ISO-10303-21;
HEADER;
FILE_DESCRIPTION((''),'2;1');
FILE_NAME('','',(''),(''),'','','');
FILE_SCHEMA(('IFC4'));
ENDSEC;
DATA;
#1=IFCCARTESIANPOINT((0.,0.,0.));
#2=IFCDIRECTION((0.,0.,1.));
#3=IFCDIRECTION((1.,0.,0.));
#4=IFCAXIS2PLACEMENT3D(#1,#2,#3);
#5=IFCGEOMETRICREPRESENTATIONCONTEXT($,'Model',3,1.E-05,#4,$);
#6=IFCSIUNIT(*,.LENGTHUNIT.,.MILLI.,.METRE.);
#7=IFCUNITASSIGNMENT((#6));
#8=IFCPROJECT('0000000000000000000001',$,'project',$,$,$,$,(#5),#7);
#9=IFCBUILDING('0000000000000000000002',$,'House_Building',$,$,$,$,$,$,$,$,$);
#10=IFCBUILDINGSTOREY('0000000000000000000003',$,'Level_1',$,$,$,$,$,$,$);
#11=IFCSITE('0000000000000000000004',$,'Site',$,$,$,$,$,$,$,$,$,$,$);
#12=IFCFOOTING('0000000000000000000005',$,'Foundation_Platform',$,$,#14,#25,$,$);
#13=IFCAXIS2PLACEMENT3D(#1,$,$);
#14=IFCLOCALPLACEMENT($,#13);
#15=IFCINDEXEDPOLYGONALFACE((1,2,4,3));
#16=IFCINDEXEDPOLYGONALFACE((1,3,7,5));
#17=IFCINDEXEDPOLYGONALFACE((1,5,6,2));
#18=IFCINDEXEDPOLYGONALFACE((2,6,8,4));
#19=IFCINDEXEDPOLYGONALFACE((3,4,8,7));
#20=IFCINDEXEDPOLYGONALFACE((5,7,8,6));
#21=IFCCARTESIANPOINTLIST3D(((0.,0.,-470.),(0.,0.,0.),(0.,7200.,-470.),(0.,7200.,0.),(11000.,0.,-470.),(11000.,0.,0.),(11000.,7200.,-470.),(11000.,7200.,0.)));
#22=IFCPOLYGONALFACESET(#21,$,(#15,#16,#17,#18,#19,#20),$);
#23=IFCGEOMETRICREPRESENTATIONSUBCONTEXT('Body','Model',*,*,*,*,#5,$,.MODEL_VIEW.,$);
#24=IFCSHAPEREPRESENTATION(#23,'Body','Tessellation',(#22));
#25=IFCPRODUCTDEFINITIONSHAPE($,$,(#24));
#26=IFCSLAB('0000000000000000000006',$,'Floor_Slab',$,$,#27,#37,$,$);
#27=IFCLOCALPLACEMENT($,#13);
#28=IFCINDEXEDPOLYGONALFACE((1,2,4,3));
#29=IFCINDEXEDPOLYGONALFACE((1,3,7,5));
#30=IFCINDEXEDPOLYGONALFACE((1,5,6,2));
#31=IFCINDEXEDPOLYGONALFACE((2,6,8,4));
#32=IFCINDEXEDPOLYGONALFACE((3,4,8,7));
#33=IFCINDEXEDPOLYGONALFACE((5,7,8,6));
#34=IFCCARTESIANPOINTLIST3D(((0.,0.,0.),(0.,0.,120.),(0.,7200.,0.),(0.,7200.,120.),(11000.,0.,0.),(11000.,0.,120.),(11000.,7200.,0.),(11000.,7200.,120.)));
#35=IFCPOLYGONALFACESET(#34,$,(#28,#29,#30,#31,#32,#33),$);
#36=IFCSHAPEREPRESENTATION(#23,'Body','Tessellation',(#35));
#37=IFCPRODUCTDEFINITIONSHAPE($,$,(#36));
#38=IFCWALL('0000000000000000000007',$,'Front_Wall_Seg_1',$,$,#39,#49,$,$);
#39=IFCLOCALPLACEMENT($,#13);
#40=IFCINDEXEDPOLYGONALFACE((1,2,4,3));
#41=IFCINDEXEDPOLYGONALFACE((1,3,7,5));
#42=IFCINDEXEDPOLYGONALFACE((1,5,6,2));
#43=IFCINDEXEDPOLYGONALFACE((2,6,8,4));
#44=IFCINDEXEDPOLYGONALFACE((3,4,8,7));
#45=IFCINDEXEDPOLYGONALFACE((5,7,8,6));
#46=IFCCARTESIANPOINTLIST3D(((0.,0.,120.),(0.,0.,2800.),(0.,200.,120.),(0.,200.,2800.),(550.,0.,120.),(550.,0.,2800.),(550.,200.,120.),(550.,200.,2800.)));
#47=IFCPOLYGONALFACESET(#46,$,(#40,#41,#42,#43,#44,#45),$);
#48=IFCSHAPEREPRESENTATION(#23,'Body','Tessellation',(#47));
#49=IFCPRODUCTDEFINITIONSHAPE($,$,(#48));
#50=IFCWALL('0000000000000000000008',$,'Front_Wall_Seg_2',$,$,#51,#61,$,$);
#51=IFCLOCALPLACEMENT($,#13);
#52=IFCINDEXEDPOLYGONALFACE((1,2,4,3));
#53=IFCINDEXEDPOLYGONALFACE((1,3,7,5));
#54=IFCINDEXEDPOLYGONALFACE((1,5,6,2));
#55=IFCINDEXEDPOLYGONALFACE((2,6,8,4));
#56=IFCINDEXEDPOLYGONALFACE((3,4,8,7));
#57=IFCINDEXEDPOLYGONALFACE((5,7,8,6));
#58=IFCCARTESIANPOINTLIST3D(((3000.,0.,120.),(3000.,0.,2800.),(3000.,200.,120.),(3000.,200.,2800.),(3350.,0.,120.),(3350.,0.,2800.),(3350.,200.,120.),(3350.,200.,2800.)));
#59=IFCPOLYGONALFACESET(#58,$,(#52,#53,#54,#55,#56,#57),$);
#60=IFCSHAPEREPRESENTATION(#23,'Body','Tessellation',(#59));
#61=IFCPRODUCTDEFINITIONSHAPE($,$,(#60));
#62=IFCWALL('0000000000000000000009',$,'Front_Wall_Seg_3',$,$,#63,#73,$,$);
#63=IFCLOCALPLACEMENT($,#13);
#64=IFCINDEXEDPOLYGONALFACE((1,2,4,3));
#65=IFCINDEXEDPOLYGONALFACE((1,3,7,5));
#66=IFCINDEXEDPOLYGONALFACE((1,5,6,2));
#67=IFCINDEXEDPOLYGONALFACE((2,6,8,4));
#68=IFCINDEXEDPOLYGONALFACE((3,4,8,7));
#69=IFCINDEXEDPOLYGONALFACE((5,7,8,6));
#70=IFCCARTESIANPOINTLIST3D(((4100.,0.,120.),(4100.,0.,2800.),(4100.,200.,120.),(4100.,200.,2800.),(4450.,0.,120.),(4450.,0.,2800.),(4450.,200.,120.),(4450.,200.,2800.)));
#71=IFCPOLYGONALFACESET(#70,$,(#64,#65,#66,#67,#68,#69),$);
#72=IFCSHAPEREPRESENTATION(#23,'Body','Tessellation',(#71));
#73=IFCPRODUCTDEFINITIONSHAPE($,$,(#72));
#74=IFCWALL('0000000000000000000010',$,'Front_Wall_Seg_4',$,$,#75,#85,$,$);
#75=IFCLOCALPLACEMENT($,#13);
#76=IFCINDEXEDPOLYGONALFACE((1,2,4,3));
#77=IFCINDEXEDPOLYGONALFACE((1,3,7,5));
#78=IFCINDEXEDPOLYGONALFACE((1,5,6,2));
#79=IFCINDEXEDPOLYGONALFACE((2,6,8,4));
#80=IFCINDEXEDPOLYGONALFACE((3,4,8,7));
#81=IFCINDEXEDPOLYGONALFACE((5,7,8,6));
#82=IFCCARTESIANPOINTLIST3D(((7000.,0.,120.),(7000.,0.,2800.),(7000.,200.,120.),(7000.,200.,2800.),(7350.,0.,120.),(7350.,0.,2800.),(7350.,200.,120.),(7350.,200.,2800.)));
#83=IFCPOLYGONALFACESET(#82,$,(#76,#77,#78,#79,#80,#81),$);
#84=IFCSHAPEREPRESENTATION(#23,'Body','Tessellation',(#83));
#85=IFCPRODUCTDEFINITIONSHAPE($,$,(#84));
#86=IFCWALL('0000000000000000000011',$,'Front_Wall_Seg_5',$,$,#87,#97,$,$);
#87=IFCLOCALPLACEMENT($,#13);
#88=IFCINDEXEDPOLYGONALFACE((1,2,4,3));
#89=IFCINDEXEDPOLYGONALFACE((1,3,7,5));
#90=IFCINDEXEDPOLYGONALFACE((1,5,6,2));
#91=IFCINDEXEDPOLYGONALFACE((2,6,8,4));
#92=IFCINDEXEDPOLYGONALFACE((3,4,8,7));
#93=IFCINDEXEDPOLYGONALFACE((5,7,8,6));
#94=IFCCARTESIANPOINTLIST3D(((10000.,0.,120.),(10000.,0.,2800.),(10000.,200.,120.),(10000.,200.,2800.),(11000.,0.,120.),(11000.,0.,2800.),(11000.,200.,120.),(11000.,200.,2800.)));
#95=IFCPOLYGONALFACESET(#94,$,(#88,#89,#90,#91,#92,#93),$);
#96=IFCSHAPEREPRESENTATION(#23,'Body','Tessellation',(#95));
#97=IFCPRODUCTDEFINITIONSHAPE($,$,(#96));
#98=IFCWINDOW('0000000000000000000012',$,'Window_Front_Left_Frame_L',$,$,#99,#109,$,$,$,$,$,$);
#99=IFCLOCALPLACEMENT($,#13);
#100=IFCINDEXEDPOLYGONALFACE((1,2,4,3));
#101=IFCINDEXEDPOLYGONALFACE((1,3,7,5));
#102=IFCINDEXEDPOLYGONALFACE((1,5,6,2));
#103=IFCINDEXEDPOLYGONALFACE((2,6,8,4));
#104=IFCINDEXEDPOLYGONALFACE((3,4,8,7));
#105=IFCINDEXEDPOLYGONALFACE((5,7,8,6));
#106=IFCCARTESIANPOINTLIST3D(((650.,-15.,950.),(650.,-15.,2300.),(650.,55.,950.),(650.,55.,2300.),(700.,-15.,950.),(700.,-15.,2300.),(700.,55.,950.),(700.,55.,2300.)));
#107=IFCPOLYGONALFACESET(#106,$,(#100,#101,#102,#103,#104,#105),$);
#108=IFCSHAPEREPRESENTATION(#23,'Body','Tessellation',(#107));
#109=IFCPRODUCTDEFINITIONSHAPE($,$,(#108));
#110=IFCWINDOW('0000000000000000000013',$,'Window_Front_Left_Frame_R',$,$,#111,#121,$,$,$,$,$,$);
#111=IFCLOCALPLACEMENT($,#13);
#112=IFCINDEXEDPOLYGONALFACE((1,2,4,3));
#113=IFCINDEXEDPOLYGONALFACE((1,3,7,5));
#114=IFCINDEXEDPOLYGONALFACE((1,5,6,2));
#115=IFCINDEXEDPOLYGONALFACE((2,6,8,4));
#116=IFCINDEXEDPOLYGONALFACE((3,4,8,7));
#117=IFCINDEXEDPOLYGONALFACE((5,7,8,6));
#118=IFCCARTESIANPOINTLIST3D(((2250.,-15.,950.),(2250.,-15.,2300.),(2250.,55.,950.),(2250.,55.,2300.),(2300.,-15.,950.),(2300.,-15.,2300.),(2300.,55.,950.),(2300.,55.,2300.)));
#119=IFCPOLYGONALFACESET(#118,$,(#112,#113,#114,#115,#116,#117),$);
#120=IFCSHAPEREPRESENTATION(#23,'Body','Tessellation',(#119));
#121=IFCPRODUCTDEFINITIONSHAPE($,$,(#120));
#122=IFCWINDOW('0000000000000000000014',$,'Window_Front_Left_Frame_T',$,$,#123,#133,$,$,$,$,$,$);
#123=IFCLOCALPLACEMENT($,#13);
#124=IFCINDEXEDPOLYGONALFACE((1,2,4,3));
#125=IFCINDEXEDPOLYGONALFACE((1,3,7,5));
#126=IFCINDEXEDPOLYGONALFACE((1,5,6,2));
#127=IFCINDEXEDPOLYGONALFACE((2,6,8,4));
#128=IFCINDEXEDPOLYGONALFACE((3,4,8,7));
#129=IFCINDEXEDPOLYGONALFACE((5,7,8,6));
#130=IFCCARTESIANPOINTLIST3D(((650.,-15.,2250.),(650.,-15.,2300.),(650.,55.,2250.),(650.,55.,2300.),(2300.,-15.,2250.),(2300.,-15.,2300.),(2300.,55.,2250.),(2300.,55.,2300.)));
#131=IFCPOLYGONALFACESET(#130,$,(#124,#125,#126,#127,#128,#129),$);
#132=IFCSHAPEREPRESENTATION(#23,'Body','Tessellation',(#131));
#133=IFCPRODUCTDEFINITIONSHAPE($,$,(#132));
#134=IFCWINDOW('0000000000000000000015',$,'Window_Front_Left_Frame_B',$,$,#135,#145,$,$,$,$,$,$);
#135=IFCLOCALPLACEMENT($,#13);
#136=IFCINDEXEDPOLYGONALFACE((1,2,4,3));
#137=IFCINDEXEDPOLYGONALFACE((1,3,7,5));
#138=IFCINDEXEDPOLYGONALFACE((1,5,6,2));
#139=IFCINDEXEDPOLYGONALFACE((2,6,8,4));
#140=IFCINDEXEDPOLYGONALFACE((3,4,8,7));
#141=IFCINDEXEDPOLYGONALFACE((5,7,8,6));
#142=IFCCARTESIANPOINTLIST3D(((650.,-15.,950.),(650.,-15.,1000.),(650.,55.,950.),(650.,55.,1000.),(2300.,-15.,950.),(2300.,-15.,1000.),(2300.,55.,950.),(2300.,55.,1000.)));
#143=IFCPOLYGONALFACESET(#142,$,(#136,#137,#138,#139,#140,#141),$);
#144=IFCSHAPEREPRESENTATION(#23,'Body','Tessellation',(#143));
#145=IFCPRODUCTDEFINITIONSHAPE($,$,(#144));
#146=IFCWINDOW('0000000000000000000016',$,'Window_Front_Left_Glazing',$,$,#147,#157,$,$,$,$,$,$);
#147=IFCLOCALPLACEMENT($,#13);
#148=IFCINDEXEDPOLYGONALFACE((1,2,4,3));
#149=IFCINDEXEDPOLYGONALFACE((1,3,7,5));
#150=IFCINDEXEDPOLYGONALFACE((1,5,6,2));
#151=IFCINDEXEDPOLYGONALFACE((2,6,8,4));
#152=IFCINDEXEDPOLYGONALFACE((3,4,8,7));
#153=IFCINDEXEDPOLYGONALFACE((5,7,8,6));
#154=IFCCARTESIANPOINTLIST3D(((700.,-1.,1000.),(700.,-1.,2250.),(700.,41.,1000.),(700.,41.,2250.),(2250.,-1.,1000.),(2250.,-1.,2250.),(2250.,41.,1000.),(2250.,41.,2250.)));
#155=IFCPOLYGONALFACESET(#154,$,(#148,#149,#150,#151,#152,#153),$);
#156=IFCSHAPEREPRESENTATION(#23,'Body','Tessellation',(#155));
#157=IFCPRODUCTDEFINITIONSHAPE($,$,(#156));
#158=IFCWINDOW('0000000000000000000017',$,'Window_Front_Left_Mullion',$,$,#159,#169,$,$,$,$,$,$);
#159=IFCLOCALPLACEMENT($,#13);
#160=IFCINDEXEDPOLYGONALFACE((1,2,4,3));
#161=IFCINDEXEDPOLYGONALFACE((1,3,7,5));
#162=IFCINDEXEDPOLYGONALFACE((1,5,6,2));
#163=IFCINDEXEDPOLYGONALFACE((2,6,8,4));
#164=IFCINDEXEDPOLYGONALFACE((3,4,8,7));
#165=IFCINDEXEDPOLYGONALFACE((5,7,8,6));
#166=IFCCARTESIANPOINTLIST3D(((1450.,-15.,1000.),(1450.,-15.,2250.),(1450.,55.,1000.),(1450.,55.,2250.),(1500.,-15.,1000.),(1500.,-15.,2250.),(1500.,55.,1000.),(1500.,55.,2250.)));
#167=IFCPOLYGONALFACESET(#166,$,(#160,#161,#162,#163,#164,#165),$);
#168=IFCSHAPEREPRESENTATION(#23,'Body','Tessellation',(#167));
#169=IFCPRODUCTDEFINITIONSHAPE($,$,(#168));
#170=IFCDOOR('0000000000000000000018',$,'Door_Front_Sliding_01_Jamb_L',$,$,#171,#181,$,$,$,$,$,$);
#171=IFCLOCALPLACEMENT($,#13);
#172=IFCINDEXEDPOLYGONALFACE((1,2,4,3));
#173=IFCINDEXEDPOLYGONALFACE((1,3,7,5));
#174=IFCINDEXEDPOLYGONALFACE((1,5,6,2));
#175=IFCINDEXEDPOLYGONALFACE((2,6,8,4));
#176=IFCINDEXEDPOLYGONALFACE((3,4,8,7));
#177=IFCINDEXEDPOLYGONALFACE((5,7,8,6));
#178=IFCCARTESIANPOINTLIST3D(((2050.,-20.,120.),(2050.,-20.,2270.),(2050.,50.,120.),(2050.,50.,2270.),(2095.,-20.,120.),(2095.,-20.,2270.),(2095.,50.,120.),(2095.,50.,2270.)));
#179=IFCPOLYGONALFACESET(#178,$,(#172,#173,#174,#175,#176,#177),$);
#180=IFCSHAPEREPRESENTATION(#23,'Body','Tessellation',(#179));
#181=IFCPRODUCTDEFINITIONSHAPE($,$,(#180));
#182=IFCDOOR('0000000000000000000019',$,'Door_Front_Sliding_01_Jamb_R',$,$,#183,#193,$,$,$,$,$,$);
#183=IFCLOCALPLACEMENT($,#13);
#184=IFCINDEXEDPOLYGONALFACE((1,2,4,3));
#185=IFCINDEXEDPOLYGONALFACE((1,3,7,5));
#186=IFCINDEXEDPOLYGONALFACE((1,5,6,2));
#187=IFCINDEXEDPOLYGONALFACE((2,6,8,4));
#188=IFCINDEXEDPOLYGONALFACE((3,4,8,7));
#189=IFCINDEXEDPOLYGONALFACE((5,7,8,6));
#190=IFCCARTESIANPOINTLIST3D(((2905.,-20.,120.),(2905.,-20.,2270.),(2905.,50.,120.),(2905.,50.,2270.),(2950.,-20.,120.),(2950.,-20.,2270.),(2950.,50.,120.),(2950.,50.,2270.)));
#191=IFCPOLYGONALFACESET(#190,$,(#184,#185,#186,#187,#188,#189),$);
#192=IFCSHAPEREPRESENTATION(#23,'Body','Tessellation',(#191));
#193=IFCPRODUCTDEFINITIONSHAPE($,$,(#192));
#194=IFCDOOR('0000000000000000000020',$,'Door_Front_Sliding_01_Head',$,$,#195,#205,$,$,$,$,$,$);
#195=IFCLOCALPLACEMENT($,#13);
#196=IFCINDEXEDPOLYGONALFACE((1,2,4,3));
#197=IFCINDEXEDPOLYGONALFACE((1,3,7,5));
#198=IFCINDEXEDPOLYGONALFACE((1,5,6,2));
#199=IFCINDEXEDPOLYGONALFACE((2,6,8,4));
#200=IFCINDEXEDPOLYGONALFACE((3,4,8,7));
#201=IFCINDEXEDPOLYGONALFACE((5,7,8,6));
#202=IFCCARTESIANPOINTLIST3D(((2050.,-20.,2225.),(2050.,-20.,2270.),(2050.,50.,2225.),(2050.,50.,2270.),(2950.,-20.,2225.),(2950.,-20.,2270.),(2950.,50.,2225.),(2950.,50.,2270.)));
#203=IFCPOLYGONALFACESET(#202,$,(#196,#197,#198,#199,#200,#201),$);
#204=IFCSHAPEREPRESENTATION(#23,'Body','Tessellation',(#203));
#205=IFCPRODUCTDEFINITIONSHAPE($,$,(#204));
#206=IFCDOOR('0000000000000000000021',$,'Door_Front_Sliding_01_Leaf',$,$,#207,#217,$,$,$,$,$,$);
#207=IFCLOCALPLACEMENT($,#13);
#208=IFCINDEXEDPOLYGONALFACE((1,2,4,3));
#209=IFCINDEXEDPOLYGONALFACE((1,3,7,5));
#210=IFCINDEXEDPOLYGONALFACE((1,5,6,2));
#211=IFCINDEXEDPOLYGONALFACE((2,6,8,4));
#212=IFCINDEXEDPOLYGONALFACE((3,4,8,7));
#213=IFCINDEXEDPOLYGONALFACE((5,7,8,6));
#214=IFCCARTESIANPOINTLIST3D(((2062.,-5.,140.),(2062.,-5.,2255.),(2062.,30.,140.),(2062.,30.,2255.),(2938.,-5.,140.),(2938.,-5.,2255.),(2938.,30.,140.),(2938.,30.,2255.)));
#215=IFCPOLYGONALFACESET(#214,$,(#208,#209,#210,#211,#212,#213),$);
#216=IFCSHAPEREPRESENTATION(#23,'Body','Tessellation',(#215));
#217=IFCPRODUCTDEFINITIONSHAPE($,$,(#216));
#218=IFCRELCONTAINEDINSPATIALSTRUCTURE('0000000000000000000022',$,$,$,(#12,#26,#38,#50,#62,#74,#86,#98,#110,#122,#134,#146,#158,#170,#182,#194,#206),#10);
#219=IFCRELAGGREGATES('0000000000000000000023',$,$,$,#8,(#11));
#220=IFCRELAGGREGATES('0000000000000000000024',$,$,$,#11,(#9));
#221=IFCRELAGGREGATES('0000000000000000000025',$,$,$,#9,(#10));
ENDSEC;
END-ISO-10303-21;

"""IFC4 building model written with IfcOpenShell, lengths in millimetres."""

from ifc_helpers import new_model, si_unit, frame, origin_with_axes, context, subcontext, project, spatial, polyline, outline, extrude, element, save


model = new_model("IFC4")

# Units and contexts
model_context = context("Model", 3, precision=1e-05, world=origin_with_axes())
body_context = subcontext(model_context, "Body", "Model", "MODEL_VIEW")
ifc_project = project(units=[si_unit("LENGTHUNIT", "METRE", prefix="MILLI")], contexts=[model_context])

# Site, building, storey
site = spatial("IfcSite", under=ifc_project, Name="Site")
building = spatial("IfcBuilding", under=site, Name="House_Building")
storey = spatial("IfcBuildingStorey", under=building, Name="Level_1")

# Footing
element("IfcFooting", 1, inside=storey, Name="Foundation_Platform", context=body_context, shape_type="SweptSolid", body=[
    extrude(outline(polyline([(0.0, 0.0), (11000.0, 0.0), (11000.0, 7200.0), (0.0, 7200.0), (0.0, 0.0)])), frame((0.0, 0.0, -470.0), z_axis=(0.0, 0.0, 1.0), x_axis=(1.0, 0.0, 0.0)), (0.0, 0.0, 1.0), 470.0),
])

# Slab
element("IfcSlab", 2, inside=storey, Name="Floor_Slab", context=body_context, shape_type="SweptSolid", body=[
    extrude(outline(polyline([(0.0, 0.0), (11000.0, 0.0), (11000.0, 7200.0), (0.0, 7200.0), (0.0, 0.0)])), origin_with_axes(), (0.0, 0.0, 1.0), 120.0),
])

# Walls
element("IfcWall", 3, inside=storey, Name="Front_Wall_Seg_1", context=body_context, shape_type="SweptSolid", body=[
    extrude(outline(polyline([(0.0, 0.0), (550.0, 0.0), (550.0, 200.0), (0.0, 200.0), (0.0, 0.0)])), frame((0.0, 0.0, 120.0), z_axis=(0.0, 0.0, 1.0), x_axis=(1.0, 0.0, 0.0)), (0.0, 0.0, 1.0), 2680.0),
])
element("IfcWall", 4, inside=storey, Name="Front_Wall_Seg_2", context=body_context, shape_type="SweptSolid", body=[
    extrude(outline(polyline([(3000.0, 0.0), (3350.0, 0.0), (3350.0, 200.0), (3000.0, 200.0), (3000.0, 0.0)])), frame((0.0, 0.0, 120.0), z_axis=(0.0, 0.0, 1.0), x_axis=(1.0, 0.0, 0.0)), (0.0, 0.0, 1.0), 2680.0),
])
element("IfcWall", 5, inside=storey, Name="Front_Wall_Seg_3", context=body_context, shape_type="SweptSolid", body=[
    extrude(outline(polyline([(4100.0, 0.0), (4450.0, 0.0), (4450.0, 200.0), (4100.0, 200.0), (4100.0, 0.0)])), frame((0.0, 0.0, 120.0), z_axis=(0.0, 0.0, 1.0), x_axis=(1.0, 0.0, 0.0)), (0.0, 0.0, 1.0), 2680.0),
])
element("IfcWall", 6, inside=storey, Name="Front_Wall_Seg_4", context=body_context, shape_type="SweptSolid", body=[
    extrude(outline(polyline([(7000.0, 0.0), (7350.0, 0.0), (7350.0, 200.0), (7000.0, 200.0), (7000.0, 0.0)])), frame((0.0, 0.0, 120.0), z_axis=(0.0, 0.0, 1.0), x_axis=(1.0, 0.0, 0.0)), (0.0, 0.0, 1.0), 2680.0),
])
element("IfcWall", 7, inside=storey, Name="Front_Wall_Seg_5", context=body_context, shape_type="SweptSolid", body=[
    extrude(outline(polyline([(10000.0, 0.0), (11000.0, 0.0), (11000.0, 200.0), (10000.0, 200.0), (10000.0, 0.0)])), frame((0.0, 0.0, 120.0), z_axis=(0.0, 0.0, 1.0), x_axis=(1.0, 0.0, 0.0)), (0.0, 0.0, 1.0), 2680.0),
])

# Windows
element("IfcWindow", 8, inside=storey, Name="Window_Front_Left_Frame_L", context=body_context, shape_type="SweptSolid", body=[
    extrude(outline(polyline([(650.0, -15.0), (700.0, -15.0), (700.0, 55.0), (650.0, 55.0), (650.0, -15.0)])), frame((0.0, 0.0, 950.0), z_axis=(0.0, 0.0, 1.0), x_axis=(1.0, 0.0, 0.0)), (0.0, 0.0, 1.0), 1350.0),
])
element("IfcWindow", 9, inside=storey, Name="Window_Front_Left_Frame_R", context=body_context, shape_type="SweptSolid", body=[
    extrude(outline(polyline([(2250.0, -15.0), (2300.0, -15.0), (2300.0, 55.0), (2250.0, 55.0), (2250.0, -15.0)])), frame((0.0, 0.0, 950.0), z_axis=(0.0, 0.0, 1.0), x_axis=(1.0, 0.0, 0.0)), (0.0, 0.0, 1.0), 1350.0),
])
element("IfcWindow", 10, inside=storey, Name="Window_Front_Left_Frame_T", context=body_context, shape_type="SweptSolid", body=[
    extrude(outline(polyline([(650.0, -15.0), (2300.0, -15.0), (2300.0, 55.0), (650.0, 55.0), (650.0, -15.0)])), frame((0.0, 0.0, 2250.0), z_axis=(0.0, 0.0, 1.0), x_axis=(1.0, 0.0, 0.0)), (0.0, 0.0, 1.0), 50.0),
])
element("IfcWindow", 11, inside=storey, Name="Window_Front_Left_Frame_B", context=body_context, shape_type="SweptSolid", body=[
    extrude(outline(polyline([(650.0, -15.0), (2300.0, -15.0), (2300.0, 55.0), (650.0, 55.0), (650.0, -15.0)])), frame((0.0, 0.0, 950.0), z_axis=(0.0, 0.0, 1.0), x_axis=(1.0, 0.0, 0.0)), (0.0, 0.0, 1.0), 50.0),
])
element("IfcWindow", 12, inside=storey, Name="Window_Front_Left_Glazing", context=body_context, shape_type="SweptSolid", body=[
    extrude(outline(polyline([(700.0, -1.0), (2250.0, -1.0), (2250.0, 41.0), (700.0, 41.0), (700.0, -1.0)])), frame((0.0, 0.0, 1000.0), z_axis=(0.0, 0.0, 1.0), x_axis=(1.0, 0.0, 0.0)), (0.0, 0.0, 1.0), 1250.0),
])
element("IfcWindow", 13, inside=storey, Name="Window_Front_Left_Mullion", context=body_context, shape_type="SweptSolid", body=[
    extrude(outline(polyline([(1450.0, -15.0), (1500.0, -15.0), (1500.0, 55.0), (1450.0, 55.0), (1450.0, -15.0)])), frame((0.0, 0.0, 1000.0), z_axis=(0.0, 0.0, 1.0), x_axis=(1.0, 0.0, 0.0)), (0.0, 0.0, 1.0), 1250.0),
])

# Doors
element("IfcDoor", 14, inside=storey, Name="Door_Front_Sliding_01_Jamb_L", context=body_context, shape_type="SweptSolid", body=[
    extrude(outline(polyline([(2050.0, -20.0), (2095.0, -20.0), (2095.0, 50.0), (2050.0, 50.0), (2050.0, -20.0)])), frame((0.0, 0.0, 120.0), z_axis=(0.0, 0.0, 1.0), x_axis=(1.0, 0.0, 0.0)), (0.0, 0.0, 1.0), 2150.0),
])
element("IfcDoor", 15, inside=storey, Name="Door_Front_Sliding_01_Jamb_R", context=body_context, shape_type="SweptSolid", body=[
    extrude(outline(polyline([(2905.0, -20.0), (2950.0, -20.0), (2950.0, 50.0), (2905.0, 50.0), (2905.0, -20.0)])), frame((0.0, 0.0, 120.0), z_axis=(0.0, 0.0, 1.0), x_axis=(1.0, 0.0, 0.0)), (0.0, 0.0, 1.0), 2150.0),
])
element("IfcDoor", 16, inside=storey, Name="Door_Front_Sliding_01_Head", context=body_context, shape_type="SweptSolid", body=[
    extrude(outline(polyline([(2050.0, -20.0), (2950.0, -20.0), (2950.0, 50.0), (2050.0, 50.0), (2050.0, -20.0)])), frame((0.0, 0.0, 2225.0), z_axis=(0.0, 0.0, 1.0), x_axis=(1.0, 0.0, 0.0)), (0.0, 0.0, 1.0), 45.0),
])
element("IfcDoor", 17, inside=storey, Name="Door_Front_Sliding_01_Leaf", context=body_context, shape_type="SweptSolid", body=[
    extrude(outline(polyline([(2062.0, -5.0), (2938.0, -5.0), (2938.0, 30.0), (2062.0, 30.0), (2062.0, -5.0)])), frame((0.0, 0.0, 140.0), z_axis=(0.0, 0.0, 1.0), x_axis=(1.0, 0.0, 0.0)), (0.0, 0.0, 1.0), 2115.0),
])

save(model, "model.ifc")
